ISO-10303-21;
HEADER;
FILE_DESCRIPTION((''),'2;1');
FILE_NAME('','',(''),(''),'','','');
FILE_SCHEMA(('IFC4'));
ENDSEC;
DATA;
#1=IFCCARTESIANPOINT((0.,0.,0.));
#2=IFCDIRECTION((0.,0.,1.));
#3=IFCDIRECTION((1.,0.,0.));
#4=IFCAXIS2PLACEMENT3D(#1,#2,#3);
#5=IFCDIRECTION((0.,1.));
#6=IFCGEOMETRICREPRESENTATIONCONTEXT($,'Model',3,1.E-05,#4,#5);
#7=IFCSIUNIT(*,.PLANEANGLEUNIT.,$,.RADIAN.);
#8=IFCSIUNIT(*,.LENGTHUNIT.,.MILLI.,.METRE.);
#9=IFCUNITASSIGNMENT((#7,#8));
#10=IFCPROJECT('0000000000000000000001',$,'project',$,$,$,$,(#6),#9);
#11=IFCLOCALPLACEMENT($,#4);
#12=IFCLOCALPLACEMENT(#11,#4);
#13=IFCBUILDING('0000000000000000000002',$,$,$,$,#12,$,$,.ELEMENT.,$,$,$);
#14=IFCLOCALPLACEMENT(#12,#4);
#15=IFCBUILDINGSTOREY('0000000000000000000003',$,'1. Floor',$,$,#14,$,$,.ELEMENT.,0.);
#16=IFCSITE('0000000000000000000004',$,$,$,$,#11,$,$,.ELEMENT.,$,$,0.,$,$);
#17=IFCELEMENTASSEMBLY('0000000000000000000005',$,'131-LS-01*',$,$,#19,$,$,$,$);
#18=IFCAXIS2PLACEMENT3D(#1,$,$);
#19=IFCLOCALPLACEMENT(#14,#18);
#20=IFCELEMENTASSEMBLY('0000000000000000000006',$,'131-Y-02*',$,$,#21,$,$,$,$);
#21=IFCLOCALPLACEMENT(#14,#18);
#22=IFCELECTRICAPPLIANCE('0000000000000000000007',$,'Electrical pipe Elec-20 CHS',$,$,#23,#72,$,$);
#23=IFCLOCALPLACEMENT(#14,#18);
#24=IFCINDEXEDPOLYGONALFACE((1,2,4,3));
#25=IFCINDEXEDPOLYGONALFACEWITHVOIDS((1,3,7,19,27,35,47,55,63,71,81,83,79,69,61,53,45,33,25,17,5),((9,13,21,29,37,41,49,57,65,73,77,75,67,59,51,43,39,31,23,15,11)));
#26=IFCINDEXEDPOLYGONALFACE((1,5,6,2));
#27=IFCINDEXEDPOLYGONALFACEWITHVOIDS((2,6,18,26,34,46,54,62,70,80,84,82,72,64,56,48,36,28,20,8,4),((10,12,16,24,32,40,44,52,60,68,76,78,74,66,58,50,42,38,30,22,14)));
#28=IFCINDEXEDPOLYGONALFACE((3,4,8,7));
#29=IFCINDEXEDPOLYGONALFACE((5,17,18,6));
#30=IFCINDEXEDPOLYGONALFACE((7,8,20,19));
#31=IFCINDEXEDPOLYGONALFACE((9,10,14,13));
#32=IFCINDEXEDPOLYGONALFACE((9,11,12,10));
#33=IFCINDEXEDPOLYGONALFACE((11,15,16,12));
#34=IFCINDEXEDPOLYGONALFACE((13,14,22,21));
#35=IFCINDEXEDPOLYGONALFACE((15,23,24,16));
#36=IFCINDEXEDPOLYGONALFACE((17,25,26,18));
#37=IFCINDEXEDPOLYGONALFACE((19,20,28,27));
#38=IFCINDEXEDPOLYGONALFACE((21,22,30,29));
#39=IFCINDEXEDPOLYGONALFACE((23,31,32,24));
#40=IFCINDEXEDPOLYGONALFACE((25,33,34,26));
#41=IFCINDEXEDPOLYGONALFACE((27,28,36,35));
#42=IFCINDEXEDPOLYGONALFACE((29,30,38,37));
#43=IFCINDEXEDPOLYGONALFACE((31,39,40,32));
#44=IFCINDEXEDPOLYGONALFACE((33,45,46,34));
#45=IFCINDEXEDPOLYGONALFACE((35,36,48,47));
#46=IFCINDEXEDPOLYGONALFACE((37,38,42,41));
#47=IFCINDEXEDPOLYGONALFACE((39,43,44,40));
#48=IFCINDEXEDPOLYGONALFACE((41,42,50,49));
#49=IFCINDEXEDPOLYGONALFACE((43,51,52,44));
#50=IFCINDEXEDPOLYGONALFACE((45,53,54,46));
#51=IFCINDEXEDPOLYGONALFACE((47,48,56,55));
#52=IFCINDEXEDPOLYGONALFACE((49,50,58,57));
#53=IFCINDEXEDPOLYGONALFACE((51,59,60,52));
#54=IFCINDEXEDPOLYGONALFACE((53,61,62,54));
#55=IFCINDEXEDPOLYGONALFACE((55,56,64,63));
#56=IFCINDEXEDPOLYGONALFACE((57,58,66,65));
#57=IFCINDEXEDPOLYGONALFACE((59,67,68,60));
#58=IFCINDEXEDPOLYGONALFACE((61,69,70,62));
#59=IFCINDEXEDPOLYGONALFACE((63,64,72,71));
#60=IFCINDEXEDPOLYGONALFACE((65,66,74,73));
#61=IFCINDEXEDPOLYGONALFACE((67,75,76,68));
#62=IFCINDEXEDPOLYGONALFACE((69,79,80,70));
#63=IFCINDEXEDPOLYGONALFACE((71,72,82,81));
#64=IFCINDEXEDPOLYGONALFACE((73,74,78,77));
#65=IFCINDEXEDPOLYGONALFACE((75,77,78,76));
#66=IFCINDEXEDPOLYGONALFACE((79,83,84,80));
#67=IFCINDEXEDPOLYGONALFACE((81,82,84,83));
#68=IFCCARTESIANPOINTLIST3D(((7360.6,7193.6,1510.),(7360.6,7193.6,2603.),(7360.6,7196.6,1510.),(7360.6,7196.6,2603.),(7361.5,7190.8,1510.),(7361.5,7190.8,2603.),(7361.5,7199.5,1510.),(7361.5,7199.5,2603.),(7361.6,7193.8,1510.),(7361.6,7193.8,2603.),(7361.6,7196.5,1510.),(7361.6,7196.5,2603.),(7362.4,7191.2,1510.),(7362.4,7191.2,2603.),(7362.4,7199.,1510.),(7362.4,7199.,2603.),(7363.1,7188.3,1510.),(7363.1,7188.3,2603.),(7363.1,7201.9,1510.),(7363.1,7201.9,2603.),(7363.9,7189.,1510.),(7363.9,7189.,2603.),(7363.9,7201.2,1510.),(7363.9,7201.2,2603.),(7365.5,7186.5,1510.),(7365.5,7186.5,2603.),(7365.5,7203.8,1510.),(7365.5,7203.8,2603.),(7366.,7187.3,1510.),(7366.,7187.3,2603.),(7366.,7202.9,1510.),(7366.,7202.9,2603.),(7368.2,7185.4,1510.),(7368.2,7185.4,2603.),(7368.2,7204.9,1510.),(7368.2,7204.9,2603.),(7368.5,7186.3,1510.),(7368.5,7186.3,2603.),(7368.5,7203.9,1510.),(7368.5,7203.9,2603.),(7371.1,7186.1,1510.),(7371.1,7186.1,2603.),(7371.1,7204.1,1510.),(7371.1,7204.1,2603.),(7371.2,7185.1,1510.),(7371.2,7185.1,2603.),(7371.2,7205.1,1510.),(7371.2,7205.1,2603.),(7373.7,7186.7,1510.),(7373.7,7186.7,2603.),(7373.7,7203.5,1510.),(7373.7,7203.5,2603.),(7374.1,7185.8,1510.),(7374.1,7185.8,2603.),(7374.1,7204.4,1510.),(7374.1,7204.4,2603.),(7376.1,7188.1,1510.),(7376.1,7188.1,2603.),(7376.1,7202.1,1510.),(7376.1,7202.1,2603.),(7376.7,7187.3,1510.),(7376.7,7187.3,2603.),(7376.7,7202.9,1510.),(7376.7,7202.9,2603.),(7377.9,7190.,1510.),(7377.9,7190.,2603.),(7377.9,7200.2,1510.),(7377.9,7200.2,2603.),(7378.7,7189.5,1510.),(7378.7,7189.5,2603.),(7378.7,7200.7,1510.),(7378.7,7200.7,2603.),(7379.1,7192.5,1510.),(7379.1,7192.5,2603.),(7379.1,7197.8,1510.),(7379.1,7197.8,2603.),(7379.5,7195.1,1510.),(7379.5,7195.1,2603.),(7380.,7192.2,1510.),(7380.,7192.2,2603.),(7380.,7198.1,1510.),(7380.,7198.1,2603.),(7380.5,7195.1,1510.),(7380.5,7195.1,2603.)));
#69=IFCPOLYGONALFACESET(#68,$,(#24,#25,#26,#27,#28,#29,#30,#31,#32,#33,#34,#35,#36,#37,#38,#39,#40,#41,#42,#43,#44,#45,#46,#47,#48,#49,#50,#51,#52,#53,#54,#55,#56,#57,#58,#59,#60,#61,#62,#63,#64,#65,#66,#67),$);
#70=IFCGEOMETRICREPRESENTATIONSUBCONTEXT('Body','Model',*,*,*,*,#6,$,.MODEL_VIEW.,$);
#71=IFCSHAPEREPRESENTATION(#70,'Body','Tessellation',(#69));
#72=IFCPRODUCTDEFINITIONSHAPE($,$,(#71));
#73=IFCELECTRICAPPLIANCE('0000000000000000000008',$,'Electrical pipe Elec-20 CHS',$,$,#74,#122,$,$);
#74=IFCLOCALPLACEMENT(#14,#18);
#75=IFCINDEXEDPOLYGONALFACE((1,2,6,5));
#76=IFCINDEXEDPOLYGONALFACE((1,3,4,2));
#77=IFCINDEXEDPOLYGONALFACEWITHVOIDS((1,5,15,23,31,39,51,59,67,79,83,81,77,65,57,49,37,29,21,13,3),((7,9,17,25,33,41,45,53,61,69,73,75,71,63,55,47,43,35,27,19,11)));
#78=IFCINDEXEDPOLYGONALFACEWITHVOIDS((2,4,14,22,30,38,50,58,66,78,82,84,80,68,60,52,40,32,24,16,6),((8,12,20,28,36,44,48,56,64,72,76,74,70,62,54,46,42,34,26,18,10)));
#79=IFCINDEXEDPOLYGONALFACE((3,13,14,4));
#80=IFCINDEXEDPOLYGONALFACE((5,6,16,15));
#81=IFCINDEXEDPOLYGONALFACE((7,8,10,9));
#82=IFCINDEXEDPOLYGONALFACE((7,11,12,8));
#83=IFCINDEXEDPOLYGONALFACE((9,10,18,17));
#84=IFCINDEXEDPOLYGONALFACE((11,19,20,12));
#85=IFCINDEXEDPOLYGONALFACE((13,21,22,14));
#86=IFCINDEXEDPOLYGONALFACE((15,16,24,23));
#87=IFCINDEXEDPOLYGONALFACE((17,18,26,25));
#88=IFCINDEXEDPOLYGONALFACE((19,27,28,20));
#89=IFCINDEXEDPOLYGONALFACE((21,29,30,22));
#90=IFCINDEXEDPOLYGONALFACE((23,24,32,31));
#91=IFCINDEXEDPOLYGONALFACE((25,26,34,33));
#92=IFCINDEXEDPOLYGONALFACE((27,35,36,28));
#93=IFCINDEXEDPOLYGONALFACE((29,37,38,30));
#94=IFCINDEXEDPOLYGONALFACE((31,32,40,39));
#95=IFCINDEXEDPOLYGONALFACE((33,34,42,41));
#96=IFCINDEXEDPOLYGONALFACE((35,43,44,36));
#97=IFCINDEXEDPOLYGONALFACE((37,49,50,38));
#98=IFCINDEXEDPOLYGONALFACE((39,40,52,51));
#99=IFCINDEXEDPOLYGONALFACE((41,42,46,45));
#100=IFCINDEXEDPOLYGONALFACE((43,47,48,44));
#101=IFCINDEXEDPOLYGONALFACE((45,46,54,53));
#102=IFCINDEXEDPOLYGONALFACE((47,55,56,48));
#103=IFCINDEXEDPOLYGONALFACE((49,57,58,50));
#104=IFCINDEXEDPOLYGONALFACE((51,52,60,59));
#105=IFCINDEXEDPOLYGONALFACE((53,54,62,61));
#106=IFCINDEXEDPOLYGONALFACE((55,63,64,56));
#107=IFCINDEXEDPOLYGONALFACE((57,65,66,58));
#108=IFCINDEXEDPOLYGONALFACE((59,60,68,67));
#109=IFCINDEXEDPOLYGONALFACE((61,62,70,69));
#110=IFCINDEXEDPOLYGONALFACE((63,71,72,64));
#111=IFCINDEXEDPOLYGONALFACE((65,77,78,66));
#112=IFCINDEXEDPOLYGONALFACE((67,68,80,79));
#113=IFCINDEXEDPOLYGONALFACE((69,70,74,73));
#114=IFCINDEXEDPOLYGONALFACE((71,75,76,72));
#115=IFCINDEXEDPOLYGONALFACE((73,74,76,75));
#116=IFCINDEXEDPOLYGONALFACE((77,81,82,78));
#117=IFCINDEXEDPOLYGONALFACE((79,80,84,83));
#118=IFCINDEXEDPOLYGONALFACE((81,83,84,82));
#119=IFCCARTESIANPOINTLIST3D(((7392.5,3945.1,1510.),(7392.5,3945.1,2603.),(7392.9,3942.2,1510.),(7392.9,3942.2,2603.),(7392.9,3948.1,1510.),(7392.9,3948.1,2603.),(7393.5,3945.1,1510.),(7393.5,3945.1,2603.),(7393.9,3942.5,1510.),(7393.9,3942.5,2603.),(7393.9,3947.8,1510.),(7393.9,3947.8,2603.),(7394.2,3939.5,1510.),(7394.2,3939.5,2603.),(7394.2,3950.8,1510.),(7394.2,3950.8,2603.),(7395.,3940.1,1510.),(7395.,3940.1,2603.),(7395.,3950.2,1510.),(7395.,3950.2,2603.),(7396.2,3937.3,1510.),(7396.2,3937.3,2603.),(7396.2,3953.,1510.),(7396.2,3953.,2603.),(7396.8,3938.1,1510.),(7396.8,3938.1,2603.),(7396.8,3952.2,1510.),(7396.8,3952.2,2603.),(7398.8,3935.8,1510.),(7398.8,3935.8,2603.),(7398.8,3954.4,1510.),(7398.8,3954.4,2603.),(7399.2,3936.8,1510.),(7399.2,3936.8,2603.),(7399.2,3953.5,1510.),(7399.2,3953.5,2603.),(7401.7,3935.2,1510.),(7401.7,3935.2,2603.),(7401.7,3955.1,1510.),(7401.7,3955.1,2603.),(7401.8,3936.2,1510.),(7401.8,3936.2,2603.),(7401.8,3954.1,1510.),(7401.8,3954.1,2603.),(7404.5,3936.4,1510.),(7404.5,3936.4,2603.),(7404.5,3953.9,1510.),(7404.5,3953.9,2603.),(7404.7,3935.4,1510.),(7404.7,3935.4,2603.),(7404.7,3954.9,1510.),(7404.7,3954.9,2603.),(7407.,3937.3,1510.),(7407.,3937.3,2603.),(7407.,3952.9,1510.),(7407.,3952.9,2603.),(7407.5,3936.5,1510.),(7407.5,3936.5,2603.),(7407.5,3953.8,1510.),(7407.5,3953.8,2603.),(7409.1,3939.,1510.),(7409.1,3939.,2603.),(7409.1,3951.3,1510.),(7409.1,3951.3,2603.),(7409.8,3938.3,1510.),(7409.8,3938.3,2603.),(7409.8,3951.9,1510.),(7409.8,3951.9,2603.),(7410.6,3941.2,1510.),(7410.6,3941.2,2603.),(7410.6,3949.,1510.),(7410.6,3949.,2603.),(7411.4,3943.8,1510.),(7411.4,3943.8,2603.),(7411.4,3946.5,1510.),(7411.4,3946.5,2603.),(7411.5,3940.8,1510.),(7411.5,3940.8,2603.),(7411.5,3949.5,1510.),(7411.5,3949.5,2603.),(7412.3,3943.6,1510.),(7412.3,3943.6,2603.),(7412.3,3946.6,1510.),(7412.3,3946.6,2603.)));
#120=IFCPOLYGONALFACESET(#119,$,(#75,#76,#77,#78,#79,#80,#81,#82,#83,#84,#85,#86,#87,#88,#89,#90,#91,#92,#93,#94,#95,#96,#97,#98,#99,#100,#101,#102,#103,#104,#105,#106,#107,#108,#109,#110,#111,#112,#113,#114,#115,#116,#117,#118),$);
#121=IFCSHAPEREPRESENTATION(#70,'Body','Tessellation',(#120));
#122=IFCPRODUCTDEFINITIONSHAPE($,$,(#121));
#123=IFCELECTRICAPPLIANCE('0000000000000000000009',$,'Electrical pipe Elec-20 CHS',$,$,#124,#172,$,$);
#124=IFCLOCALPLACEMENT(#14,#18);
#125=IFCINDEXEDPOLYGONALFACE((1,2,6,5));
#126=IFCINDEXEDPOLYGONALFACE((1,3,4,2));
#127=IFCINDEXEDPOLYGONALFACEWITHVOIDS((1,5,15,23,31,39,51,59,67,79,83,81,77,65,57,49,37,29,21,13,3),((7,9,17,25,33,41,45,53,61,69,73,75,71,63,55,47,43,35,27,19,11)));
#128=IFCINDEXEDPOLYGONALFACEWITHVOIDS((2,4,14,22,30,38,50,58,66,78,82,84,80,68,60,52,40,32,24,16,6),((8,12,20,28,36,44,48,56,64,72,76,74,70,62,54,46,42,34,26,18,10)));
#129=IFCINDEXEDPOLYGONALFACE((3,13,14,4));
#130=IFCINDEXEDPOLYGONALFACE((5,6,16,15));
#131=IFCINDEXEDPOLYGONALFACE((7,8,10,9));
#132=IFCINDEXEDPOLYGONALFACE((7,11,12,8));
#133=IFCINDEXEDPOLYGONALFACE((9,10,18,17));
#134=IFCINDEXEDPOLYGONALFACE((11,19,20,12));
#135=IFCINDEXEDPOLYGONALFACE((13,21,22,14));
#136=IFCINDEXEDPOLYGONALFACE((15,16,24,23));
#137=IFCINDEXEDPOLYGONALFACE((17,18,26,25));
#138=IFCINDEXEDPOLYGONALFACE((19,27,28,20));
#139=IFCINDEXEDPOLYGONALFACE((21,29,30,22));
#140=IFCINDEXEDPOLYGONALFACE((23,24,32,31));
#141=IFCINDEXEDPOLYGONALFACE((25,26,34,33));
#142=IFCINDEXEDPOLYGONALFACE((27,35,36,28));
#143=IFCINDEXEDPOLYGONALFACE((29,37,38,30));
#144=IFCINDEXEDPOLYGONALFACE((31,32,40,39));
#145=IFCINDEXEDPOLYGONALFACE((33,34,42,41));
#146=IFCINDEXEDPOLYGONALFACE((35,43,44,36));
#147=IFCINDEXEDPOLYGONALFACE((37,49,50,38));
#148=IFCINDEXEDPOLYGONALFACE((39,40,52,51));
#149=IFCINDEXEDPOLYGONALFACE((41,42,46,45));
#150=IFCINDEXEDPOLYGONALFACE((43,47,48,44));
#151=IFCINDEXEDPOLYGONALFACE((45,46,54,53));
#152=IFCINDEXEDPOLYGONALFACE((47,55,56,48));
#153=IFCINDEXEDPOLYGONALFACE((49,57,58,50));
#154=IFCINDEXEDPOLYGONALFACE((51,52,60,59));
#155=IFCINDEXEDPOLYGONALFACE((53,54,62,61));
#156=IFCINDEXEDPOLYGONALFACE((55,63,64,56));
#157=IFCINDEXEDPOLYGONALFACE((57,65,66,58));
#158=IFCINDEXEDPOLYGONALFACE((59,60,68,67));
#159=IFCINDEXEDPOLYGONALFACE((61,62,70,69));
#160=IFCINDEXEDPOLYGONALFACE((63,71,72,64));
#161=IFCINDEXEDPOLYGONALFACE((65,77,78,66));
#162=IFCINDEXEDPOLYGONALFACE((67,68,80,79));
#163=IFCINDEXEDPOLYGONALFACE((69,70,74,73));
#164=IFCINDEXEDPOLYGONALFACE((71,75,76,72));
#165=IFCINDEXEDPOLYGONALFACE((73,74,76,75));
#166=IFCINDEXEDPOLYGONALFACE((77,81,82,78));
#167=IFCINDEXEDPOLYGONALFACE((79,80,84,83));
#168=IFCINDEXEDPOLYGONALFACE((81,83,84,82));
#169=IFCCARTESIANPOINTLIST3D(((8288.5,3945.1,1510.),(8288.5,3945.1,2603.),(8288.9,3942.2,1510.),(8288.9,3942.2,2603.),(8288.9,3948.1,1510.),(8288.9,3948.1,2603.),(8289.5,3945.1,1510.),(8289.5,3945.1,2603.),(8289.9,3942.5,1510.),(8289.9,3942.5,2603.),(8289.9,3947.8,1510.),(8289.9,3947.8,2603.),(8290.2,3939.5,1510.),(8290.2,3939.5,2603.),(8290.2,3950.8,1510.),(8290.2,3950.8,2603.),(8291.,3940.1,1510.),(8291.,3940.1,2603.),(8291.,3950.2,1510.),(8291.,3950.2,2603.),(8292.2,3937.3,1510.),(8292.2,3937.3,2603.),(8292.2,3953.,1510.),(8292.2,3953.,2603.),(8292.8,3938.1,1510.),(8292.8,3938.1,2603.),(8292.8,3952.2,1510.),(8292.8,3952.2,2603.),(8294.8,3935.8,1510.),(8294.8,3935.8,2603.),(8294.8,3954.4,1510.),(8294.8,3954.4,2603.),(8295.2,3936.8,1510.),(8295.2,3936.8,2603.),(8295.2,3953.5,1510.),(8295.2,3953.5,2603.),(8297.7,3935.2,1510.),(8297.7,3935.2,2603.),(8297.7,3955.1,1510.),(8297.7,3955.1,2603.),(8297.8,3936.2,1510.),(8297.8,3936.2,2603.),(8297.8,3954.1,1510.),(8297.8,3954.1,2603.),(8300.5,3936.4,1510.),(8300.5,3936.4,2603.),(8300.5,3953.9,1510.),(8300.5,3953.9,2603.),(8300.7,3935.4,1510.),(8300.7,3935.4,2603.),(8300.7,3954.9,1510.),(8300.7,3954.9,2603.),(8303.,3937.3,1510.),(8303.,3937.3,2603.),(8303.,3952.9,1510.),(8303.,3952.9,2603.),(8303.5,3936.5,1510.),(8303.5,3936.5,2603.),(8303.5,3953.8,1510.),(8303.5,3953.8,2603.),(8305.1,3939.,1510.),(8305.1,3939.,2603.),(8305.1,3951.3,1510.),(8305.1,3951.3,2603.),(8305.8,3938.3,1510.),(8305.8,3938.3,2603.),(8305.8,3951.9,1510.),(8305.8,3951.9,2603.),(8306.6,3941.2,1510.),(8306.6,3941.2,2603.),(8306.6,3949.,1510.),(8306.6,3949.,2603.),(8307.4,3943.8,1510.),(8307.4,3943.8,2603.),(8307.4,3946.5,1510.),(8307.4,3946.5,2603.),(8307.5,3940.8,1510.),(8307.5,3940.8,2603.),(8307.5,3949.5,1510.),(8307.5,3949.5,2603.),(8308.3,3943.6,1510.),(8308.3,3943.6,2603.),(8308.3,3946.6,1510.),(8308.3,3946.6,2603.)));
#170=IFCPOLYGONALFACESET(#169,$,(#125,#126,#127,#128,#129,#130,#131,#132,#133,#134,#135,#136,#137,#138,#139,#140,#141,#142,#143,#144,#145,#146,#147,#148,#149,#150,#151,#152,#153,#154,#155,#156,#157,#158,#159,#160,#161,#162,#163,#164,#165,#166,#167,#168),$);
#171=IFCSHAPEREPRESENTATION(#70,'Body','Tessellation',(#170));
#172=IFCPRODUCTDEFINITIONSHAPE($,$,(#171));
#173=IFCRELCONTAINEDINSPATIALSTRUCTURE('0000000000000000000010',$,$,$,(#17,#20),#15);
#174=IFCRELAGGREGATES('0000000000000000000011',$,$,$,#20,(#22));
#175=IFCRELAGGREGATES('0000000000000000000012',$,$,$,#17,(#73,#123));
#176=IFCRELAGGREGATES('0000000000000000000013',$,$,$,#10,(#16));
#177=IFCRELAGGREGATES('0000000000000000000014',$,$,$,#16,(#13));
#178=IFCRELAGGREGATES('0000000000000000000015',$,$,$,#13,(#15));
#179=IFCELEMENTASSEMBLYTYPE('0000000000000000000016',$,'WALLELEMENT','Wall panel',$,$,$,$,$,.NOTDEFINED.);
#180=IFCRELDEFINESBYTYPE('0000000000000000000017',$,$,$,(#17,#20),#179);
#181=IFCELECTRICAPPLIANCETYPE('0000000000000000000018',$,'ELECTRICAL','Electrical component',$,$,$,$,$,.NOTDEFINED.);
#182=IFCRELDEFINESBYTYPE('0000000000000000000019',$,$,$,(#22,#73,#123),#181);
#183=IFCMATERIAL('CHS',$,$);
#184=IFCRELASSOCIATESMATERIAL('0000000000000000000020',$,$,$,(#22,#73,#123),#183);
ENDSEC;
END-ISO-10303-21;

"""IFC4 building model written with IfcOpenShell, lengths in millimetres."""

from ifc_helpers import new_model, si_unit, direction, frame, origin_with_axes, origin_2d_with_axis, place, context, subcontext, project, spatial, hollow_circle, extrude, material, type_object, element, aggregate, save


model = new_model("IFC4")

# Units and contexts
model_context = context("Model", 3, precision=1e-05, world=origin_with_axes(), true_north=direction((0.0, 1.0)))
body_context = subcontext(model_context, "Body", "Model", "MODEL_VIEW")
ifc_project = project(units=[si_unit("PLANEANGLEUNIT", "RADIAN"), si_unit("LENGTHUNIT", "METRE", prefix="MILLI")], contexts=[model_context])

# Site, building, storey
site_placement = place(None, origin_with_axes())
site = spatial("IfcSite", under=ifc_project, at=site_placement, CompositionType="ELEMENT", RefElevation=0.0)
building_placement = place(site_placement, origin_with_axes())
building = spatial("IfcBuilding", under=site, at=building_placement, CompositionType="ELEMENT")
storey_placement = place(building_placement, origin_with_axes())
storey = spatial("IfcBuildingStorey", under=building, at=storey_placement, Name="1. Floor", CompositionType="ELEMENT", Elevation=0.0)

# Element assembly
element_assembly_type_1 = type_object("IfcElementAssemblyType", Name="WALLELEMENT", Description="Wall panel", PredefinedType="NOTDEFINED")
assembly_1_placement = place(storey_placement, origin_with_axes())
assembly_1 = element("IfcElementAssembly", 1, at=assembly_1_placement, inside=storey, type_object=element_assembly_type_1, Name="131-LS-01*")

# Element assembly, electric appliance
assembly_2_placement = place(storey_placement, origin_with_axes())
assembly_2 = element("IfcElementAssembly", 2, at=assembly_2_placement, inside=storey, type_object=element_assembly_type_1, Name="131-Y-02*")
ifc_material_1 = material(Name="CHS")
electric_appliance_type = type_object("IfcElectricApplianceType", Name="ELECTRICAL", Description="Electrical component", PredefinedType="NOTDEFINED")
electric_appliance_1_placement = place(storey_placement, frame((7370.5, 7195.1, 1510.0), z_axis=(0.0, 0.0, 1.0), x_axis=(1.0, 0.0, 0.0)))
electric_appliance_1 = element("IfcElectricAppliance", 3, at=electric_appliance_1_placement, type_object=electric_appliance_type, material=ifc_material_1, Name="Electrical pipe Elec-20 CHS", context=body_context, shape_type="SweptSolid", body=[
    extrude(hollow_circle(Radius=10.0, WallThickness=1.0, at=origin_2d_with_axis()), origin_with_axes(), (0.0, 0.0, 1.0), 1093.0),
])
aggregate(assembly_2, [electric_appliance_1])

# Electric appliances
electric_appliance_2_placement = place(storey_placement, frame((7402.5, 3945.1, 1510.0), z_axis=(0.0, 0.0, 1.0), x_axis=(-1.0, 0.0, 0.0)))
electric_appliance_2 = element("IfcElectricAppliance", 4, at=electric_appliance_2_placement, type_object=electric_appliance_type, material=ifc_material_1, Name="Electrical pipe Elec-20 CHS", context=body_context, shape_type="SweptSolid", body=[
    extrude(hollow_circle(Radius=10.0, WallThickness=1.0, at=origin_2d_with_axis()), origin_with_axes(), (0.0, 0.0, 1.0), 1093.0),
])
electric_appliance_3_placement = place(storey_placement, frame((8298.5, 3945.1, 1510.0), z_axis=(0.0, 0.0, 1.0), x_axis=(-1.0, 0.0, 0.0)))
electric_appliance_3 = element("IfcElectricAppliance", 5, at=electric_appliance_3_placement, type_object=electric_appliance_type, material=ifc_material_1, Name="Electrical pipe Elec-20 CHS", context=body_context, shape_type="SweptSolid", body=[
    extrude(hollow_circle(Radius=10.0, WallThickness=1.0, at=origin_2d_with_axis()), origin_with_axes(), (0.0, 0.0, 1.0), 1093.0),
])
aggregate(assembly_1, [electric_appliance_2, electric_appliance_3])

save(model, "model.ifc")
